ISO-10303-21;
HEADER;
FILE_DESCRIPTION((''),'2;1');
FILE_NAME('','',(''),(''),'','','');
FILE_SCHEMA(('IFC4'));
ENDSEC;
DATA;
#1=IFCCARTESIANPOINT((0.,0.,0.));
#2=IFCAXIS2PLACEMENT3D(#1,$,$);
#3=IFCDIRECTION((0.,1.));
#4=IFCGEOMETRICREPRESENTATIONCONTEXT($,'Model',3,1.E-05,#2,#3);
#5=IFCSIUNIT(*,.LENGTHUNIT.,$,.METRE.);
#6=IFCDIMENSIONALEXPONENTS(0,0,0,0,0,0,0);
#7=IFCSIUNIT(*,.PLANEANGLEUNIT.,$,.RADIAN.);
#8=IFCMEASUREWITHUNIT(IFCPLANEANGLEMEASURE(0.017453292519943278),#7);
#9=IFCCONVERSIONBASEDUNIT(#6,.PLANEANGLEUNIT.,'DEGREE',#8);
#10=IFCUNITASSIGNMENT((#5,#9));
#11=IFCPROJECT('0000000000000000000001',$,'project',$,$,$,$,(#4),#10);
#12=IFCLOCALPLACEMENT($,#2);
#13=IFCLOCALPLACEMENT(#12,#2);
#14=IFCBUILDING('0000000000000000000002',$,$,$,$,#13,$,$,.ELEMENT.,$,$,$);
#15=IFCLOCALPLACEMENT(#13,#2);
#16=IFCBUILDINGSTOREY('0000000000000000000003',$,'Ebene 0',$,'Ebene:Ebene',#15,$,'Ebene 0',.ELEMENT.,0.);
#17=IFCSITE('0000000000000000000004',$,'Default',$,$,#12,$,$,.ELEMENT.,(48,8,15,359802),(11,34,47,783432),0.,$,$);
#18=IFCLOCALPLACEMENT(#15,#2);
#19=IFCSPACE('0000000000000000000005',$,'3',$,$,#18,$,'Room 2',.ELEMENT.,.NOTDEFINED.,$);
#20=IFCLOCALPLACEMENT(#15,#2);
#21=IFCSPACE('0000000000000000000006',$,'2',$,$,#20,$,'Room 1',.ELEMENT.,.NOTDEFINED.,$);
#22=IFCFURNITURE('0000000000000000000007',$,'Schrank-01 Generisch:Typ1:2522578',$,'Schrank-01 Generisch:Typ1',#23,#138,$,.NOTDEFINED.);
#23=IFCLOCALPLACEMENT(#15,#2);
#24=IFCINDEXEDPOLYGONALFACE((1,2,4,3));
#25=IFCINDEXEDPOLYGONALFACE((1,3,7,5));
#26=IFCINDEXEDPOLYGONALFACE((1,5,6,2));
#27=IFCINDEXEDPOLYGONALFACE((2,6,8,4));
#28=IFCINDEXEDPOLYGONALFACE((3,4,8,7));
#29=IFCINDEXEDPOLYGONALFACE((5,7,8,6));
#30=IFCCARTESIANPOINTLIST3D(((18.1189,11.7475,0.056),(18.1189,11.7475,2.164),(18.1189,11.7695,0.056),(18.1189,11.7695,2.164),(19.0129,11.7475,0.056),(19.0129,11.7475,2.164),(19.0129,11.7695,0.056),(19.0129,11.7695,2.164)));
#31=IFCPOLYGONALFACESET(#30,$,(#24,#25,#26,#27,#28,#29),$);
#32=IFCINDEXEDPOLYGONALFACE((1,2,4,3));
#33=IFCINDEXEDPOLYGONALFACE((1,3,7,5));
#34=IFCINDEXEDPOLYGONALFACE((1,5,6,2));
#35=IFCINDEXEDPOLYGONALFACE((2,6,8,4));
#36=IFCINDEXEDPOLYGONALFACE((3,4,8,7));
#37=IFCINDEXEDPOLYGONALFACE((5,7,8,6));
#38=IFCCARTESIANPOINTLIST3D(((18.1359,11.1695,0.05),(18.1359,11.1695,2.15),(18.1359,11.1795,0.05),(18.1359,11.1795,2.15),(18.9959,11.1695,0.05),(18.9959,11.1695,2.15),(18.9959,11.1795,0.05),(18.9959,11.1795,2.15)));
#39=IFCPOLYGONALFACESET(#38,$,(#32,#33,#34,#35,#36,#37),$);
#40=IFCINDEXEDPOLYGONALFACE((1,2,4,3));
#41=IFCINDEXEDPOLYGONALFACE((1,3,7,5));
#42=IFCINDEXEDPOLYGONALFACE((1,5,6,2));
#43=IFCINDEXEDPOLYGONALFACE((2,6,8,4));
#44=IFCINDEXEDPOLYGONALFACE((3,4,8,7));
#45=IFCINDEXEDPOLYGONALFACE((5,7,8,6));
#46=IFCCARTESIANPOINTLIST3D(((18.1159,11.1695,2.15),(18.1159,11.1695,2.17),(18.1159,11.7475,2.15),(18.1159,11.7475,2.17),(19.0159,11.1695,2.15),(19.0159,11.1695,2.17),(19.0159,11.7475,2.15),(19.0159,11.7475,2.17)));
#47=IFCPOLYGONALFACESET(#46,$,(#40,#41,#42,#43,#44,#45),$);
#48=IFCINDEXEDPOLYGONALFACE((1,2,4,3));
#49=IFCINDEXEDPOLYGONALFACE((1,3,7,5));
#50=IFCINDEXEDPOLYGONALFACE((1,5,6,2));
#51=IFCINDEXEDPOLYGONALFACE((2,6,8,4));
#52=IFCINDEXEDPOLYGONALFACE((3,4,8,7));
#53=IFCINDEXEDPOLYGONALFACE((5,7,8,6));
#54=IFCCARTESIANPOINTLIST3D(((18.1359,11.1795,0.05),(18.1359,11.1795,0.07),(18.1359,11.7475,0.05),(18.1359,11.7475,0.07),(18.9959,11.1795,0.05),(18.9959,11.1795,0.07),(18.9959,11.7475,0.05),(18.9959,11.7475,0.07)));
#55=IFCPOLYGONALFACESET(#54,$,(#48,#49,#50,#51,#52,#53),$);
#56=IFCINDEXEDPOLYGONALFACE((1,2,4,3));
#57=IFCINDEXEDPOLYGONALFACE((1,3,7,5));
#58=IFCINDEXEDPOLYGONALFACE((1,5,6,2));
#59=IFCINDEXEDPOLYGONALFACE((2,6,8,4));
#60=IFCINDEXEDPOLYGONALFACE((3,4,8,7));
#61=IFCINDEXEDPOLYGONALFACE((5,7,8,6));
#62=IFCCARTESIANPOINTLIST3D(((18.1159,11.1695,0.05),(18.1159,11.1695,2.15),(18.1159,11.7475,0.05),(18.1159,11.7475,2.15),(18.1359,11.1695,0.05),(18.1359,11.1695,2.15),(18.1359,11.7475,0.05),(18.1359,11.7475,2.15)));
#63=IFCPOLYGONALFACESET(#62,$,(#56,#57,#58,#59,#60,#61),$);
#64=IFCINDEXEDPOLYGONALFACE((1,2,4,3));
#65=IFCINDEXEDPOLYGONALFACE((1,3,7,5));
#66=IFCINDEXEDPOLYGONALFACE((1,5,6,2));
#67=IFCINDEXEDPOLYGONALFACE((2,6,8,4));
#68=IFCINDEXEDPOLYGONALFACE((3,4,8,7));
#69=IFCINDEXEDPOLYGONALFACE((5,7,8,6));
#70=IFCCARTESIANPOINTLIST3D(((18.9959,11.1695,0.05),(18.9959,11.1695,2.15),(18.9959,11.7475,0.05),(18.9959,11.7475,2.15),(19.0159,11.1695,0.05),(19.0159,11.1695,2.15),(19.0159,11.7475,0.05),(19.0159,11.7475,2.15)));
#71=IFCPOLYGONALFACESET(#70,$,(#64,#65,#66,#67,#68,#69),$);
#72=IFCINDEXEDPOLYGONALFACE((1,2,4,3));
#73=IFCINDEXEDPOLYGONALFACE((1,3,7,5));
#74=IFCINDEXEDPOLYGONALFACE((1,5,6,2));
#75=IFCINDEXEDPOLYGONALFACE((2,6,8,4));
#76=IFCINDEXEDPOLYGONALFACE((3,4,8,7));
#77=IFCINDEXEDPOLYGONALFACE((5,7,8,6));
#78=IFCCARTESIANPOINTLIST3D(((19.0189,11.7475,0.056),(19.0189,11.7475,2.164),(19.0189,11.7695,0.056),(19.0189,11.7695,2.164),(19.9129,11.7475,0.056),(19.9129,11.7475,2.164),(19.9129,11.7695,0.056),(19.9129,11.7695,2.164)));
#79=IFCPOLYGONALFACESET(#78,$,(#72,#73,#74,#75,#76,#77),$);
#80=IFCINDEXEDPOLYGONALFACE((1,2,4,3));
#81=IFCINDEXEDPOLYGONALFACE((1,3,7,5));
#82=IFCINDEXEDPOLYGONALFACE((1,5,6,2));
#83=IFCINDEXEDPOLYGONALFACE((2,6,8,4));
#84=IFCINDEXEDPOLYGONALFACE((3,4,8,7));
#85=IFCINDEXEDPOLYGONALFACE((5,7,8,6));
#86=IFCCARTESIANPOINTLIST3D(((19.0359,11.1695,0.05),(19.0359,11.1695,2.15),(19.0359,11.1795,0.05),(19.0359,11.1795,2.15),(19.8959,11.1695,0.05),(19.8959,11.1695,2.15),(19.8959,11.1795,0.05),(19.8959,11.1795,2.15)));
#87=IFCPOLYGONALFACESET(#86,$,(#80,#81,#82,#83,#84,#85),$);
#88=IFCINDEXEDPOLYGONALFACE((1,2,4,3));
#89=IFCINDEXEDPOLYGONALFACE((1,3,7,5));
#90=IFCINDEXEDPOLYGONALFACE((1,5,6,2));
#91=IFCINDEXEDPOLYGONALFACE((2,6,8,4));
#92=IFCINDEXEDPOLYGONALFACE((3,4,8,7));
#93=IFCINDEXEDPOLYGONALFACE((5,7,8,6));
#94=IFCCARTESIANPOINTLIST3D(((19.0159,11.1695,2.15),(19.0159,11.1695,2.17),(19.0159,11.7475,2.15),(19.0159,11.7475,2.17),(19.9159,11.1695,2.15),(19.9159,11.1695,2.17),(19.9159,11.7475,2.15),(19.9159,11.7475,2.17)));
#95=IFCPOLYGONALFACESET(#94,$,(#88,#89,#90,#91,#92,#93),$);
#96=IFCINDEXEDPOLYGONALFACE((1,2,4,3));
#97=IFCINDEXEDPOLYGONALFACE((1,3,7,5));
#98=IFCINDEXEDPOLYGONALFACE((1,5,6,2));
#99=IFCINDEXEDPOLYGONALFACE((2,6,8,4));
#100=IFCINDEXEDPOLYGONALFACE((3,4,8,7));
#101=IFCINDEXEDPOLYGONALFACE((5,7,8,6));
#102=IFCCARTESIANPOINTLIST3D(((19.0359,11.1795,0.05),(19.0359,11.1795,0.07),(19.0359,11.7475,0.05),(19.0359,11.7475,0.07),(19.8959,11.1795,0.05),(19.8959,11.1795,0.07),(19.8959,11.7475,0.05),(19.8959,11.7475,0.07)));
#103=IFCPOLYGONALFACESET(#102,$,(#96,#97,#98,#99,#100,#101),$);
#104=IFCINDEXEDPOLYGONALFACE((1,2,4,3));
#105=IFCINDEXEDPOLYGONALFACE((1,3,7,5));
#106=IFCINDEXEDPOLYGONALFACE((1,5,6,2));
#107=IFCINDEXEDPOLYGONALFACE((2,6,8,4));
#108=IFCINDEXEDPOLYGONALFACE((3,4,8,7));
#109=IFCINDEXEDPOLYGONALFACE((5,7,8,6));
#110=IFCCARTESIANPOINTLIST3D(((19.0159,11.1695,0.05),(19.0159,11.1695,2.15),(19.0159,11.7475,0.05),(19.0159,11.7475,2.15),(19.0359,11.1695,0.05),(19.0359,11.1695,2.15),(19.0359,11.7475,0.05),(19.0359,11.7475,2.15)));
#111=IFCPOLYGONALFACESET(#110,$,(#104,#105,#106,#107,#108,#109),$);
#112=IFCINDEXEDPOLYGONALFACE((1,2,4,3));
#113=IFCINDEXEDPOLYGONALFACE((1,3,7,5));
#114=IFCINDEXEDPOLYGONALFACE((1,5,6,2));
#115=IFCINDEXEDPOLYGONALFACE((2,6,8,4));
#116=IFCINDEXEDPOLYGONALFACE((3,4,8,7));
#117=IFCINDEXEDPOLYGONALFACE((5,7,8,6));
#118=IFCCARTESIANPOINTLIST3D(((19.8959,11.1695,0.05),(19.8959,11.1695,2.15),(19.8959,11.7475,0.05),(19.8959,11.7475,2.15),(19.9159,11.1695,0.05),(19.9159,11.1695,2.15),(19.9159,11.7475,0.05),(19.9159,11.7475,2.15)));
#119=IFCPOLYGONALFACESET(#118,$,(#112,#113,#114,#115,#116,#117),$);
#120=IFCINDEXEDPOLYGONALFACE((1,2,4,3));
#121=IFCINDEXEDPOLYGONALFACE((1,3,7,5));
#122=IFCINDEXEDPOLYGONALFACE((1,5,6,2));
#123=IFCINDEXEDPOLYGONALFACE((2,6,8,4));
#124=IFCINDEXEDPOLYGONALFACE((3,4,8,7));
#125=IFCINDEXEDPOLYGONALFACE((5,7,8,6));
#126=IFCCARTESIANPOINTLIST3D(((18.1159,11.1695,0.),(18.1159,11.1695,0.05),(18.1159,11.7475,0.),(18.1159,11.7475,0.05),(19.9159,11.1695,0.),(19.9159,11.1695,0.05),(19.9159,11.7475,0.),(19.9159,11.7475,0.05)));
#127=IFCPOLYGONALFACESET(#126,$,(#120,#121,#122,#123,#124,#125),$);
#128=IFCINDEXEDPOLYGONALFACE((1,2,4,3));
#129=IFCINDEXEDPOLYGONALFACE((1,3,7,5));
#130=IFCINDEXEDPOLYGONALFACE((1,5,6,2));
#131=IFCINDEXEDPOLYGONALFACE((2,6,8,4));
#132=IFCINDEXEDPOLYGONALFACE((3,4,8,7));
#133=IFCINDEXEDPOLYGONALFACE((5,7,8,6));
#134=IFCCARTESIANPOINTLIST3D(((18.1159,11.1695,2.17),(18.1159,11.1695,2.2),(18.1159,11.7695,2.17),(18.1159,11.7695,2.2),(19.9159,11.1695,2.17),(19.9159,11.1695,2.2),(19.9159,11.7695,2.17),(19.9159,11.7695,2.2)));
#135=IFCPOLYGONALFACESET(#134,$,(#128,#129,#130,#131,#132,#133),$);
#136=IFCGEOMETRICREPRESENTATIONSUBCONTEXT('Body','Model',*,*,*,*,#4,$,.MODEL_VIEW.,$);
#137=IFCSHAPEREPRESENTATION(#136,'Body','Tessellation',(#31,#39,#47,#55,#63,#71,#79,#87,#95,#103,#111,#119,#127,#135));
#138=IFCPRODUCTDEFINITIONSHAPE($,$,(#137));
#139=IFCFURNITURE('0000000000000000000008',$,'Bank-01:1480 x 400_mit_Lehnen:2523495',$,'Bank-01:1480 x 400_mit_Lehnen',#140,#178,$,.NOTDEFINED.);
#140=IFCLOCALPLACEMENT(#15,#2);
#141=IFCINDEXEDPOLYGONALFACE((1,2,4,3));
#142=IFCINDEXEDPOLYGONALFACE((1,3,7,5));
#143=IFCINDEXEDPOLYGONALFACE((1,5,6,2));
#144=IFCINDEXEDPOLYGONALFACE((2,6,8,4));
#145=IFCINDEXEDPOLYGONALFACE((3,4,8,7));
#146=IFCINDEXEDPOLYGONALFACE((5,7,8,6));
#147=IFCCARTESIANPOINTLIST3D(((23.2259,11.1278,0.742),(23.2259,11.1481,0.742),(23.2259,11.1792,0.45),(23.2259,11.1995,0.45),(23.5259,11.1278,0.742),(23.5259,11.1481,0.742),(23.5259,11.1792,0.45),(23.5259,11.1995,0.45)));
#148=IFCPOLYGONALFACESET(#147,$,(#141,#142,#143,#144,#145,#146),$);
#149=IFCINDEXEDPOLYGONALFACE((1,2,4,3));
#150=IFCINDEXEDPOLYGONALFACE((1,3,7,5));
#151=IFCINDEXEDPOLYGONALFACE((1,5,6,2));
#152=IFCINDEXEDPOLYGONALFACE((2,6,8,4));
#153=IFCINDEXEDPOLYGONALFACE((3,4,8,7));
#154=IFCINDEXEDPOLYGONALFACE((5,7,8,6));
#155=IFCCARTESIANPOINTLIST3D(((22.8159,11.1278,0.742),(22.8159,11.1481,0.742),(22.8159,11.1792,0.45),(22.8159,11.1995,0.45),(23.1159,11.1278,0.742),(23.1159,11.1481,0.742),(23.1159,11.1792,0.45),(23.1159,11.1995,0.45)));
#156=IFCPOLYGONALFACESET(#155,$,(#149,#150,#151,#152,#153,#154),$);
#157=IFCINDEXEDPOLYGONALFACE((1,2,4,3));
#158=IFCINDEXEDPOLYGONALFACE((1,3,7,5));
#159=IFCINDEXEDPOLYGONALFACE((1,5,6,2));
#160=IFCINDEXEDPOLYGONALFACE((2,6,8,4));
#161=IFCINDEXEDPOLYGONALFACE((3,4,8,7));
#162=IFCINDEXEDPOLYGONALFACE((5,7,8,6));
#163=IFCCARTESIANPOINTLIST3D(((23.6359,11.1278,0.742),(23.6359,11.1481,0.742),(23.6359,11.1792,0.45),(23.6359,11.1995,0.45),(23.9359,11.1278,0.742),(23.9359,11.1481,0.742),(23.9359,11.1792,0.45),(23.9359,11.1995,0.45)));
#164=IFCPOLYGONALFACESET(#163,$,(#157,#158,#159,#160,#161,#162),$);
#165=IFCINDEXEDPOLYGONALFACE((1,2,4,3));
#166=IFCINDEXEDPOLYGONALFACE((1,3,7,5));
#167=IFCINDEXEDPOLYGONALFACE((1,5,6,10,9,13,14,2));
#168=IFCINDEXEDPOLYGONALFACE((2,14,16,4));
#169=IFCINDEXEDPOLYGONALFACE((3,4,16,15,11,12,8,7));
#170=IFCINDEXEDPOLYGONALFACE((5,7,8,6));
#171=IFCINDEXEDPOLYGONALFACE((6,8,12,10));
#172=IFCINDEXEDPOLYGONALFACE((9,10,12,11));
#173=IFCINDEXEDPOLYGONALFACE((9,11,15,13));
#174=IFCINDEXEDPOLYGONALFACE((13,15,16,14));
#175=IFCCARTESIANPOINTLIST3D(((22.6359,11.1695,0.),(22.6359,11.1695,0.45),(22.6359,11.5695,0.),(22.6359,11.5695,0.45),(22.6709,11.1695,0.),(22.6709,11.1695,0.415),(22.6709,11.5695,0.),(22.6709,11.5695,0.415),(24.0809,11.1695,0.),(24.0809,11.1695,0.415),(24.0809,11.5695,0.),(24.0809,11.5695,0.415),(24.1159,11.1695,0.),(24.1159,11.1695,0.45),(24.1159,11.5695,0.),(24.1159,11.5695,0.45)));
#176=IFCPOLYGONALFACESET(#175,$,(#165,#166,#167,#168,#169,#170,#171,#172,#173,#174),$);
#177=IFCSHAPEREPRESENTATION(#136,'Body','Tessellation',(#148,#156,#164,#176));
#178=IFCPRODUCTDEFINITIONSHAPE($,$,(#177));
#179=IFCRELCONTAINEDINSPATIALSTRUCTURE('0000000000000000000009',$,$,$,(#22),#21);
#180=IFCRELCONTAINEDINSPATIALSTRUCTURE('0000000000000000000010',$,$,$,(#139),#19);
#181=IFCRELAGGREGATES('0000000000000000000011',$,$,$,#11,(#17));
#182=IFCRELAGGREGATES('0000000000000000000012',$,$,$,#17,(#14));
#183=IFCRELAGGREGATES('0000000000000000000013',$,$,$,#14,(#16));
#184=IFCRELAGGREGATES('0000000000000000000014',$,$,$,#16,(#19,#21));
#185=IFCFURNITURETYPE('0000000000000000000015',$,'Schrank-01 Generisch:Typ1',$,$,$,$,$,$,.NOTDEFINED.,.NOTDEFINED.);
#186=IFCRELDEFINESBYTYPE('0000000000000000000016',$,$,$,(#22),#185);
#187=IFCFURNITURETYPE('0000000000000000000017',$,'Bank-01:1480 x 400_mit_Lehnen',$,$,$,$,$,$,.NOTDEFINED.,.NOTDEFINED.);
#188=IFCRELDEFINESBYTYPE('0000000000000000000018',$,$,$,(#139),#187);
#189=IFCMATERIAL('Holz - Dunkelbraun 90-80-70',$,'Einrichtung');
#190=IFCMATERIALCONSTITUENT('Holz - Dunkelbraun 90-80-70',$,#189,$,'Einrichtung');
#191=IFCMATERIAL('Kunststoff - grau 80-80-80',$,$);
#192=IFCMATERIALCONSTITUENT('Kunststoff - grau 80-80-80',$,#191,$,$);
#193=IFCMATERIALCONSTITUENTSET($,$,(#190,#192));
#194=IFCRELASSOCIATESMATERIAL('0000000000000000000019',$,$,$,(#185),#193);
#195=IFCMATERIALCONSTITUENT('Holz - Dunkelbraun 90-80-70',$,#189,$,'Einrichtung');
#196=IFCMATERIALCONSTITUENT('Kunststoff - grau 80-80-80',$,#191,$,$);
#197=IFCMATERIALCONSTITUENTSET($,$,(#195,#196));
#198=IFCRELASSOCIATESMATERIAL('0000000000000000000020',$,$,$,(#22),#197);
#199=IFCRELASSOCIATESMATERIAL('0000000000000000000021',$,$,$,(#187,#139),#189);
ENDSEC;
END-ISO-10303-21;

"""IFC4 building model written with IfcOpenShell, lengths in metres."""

from ifc_helpers import new_model, entity, si_unit, converted_unit, direction, frame, origin, place, context, subcontext, project, spatial, indexed_curve, outline, extrude, source, transform, mapped, material, constituent, constituent_set, type_object, type_shapes, element, save


model = new_model("IFC4")

# Units and contexts
model_context = context("Model", 3, precision=1e-05, world=origin(), true_north=direction((0.0, 1.0)))
body_context = subcontext(model_context, "Body", "Model", "MODEL_VIEW")
ifc_project = project(units=[si_unit("LENGTHUNIT", "METRE"), converted_unit("PLANEANGLEUNIT", "DEGREE", entity("IfcPlaneAngleMeasure", 0.017453292519943278), si_unit("PLANEANGLEUNIT", "RADIAN"), dimensions=[0, 0, 0, 0, 0, 0, 0])], contexts=[model_context])

# Site, building, storey
site_placement = place(None, origin())
site = spatial("IfcSite", under=ifc_project, at=site_placement, Name="Default", CompositionType="ELEMENT", RefLatitude=(48, 8, 15, 359802), RefLongitude=(11, 34, 47, 783432), RefElevation=0.0)
building_placement = place(site_placement, origin())
building = spatial("IfcBuilding", under=site, at=building_placement, CompositionType="ELEMENT")
storey_placement = place(building_placement, origin())
storey = spatial("IfcBuildingStorey", under=building, at=storey_placement, Name="Ebene 0", ObjectType="Ebene:Ebene", LongName="Ebene 0", CompositionType="ELEMENT", Elevation=0.0)

# Shared definitions
ifc_material_1 = material(Name="Holz - Dunkelbraun 90-80-70", Category="Einrichtung")
ifc_material_2 = material(Name="Kunststoff - grau 80-80-80")

# Shared definitions
ifc_constituent_1 = constituent(ifc_material_1, Name="Holz - Dunkelbraun 90-80-70", Category="Einrichtung")
ifc_constituent_2 = constituent(ifc_material_2, Name="Kunststoff - grau 80-80-80")
ifc_constituent_set_1 = constituent_set(constituents=[ifc_constituent_1, ifc_constituent_2])
furniture_type_1 = type_object("IfcFurnitureType", Name="Schrank-01 Generisch:Typ1", AssemblyPlace="NOTDEFINED", PredefinedType="NOTDEFINED", material=ifc_constituent_set_1)
shared_shape_1 = source(origin(), body_context, "Body", "SweptSolid", [
    extrude(outline(indexed_curve([(-0.447, -0.011), (0.447, -0.011), (0.447, 0.011), (-0.447, 0.011), (-0.447, -0.011)], self_intersect=False)), frame((0.45, -0.289, 0.056), z_axis=(0.0, 0.0, 1.0), x_axis=(-1.0, 0.0, 0.0)), (0.0, 0.0, 1.0), 2.108),
    extrude(outline(indexed_curve([(-0.43, -0.005), (0.43, -0.005), (0.43, 0.005), (-0.43, 0.005), (-0.43, -0.005)], self_intersect=False)), frame((0.45, 0.295, 0.05), z_axis=(0.0, 0.0, 1.0), x_axis=(-1.0, 0.0, 0.0)), (0.0, 0.0, 1.0), 2.1),
    extrude(outline(indexed_curve([(-0.45, -0.289), (0.45, -0.289), (0.45, 0.289), (-0.45, 0.289), (-0.45, -0.289)], self_intersect=False)), frame((0.45, 0.011, 2.15), z_axis=(0.0, 0.0, 1.0), x_axis=(-1.0, 0.0, 0.0)), (0.0, 0.0, 1.0), 0.02),
    extrude(outline(indexed_curve([(-0.43, -0.284), (0.43, -0.284), (0.43, 0.284), (-0.43, 0.284), (-0.43, -0.284)], self_intersect=False)), frame((0.45, 0.006, 0.05), z_axis=(0.0, 0.0, 1.0), x_axis=(-1.0, 0.0, 0.0)), (0.0, 0.0, 1.0), 0.02),
    extrude(outline(indexed_curve([(-0.01, -0.289), (0.01, -0.289), (0.01, 0.289), (-0.01, 0.289), (-0.01, -0.289)], self_intersect=False)), frame((0.89, 0.011, 0.05), z_axis=(0.0, 0.0, 1.0), x_axis=(-1.0, 0.0, 0.0)), (0.0, 0.0, 1.0), 2.1),
    extrude(outline(indexed_curve([(-0.01, -0.289), (0.01, -0.289), (0.01, 0.289), (-0.01, 0.289), (-0.01, -0.289)], self_intersect=False)), frame((0.01, 0.011, 0.05), z_axis=(0.0, 0.0, 1.0), x_axis=(-1.0, 0.0, 0.0)), (0.0, 0.0, 1.0), 2.1),
    extrude(outline(indexed_curve([(-0.447, -0.011), (0.447, -0.011), (0.447, 0.011), (-0.447, 0.011), (-0.447, -0.011)], self_intersect=False)), frame((-0.45, -0.289, 0.056), z_axis=(0.0, 0.0, 1.0), x_axis=(-1.0, 0.0, 0.0)), (0.0, 0.0, 1.0), 2.108),
    extrude(outline(indexed_curve([(-0.43, -0.005), (0.43, -0.005), (0.43, 0.005), (-0.43, 0.005), (-0.43, -0.005)], self_intersect=False)), frame((-0.45, 0.295, 0.05), z_axis=(0.0, 0.0, 1.0), x_axis=(-1.0, 0.0, 0.0)), (0.0, 0.0, 1.0), 2.1),
    extrude(outline(indexed_curve([(-0.45, -0.289), (0.45, -0.289), (0.45, 0.289), (-0.45, 0.289), (-0.45, -0.289)], self_intersect=False)), frame((-0.45, 0.011, 2.15), z_axis=(0.0, 0.0, 1.0), x_axis=(-1.0, 0.0, 0.0)), (0.0, 0.0, 1.0), 0.02),
    extrude(outline(indexed_curve([(-0.43, -0.284), (0.43, -0.284), (0.43, 0.284), (-0.43, 0.284), (-0.43, -0.284)], self_intersect=False)), frame((-0.45, 0.006, 0.05), z_axis=(0.0, 0.0, 1.0), x_axis=(-1.0, 0.0, 0.0)), (0.0, 0.0, 1.0), 0.02),
    extrude(outline(indexed_curve([(-0.01, -0.289), (0.01, -0.289), (0.01, 0.289), (-0.01, 0.289), (-0.01, -0.289)], self_intersect=False)), frame((-0.01, 0.011, 0.05), z_axis=(0.0, 0.0, 1.0), x_axis=(-1.0, 0.0, 0.0)), (0.0, 0.0, 1.0), 2.1),
    extrude(outline(indexed_curve([(-0.01, -0.289), (0.01, -0.289), (0.01, 0.289), (-0.01, 0.289), (-0.01, -0.289)], self_intersect=False)), frame((-0.89, 0.011, 0.05), z_axis=(0.0, 0.0, 1.0), x_axis=(-1.0, 0.0, 0.0)), (0.0, 0.0, 1.0), 2.1),
    extrude(outline(indexed_curve([(-0.9, -0.289), (0.9, -0.289), (0.9, 0.289), (-0.9, 0.289), (-0.9, -0.289)], self_intersect=False)), frame((0.0, 0.011, 0.0), z_axis=(0.0, 0.0, 1.0), x_axis=(-1.0, 0.0, 0.0)), (0.0, 0.0, 1.0), 0.05),
    extrude(outline(indexed_curve([(-0.9, -0.3), (0.9, -0.3), (0.9, 0.3), (-0.9, 0.3), (-0.9, -0.3)], self_intersect=False)), frame((0.0, 0.0, 2.17), z_axis=(0.0, 0.0, 1.0), x_axis=(-1.0, 0.0, 0.0)), (0.0, 0.0, 1.0), 0.03),
])
type_shapes(furniture_type_1, [shared_shape_1])

# Shared definitions
space_1_placement = place(storey_placement, origin())
space_1 = spatial("IfcSpace", under=storey, at=space_1_placement, Name="3", LongName="Room 2", CompositionType="ELEMENT", PredefinedType="NOTDEFINED")

# Shared definitions
space_2_placement = place(storey_placement, origin())
space_2 = spatial("IfcSpace", under=storey, at=space_2_placement, Name="2", LongName="Room 1", CompositionType="ELEMENT", PredefinedType="NOTDEFINED")

# Furniture
ifc_constituent_3 = constituent(ifc_material_1, Name="Holz - Dunkelbraun 90-80-70", Category="Einrichtung")
ifc_constituent_4 = constituent(ifc_material_2, Name="Kunststoff - grau 80-80-80")
ifc_constituent_set_2 = constituent_set(constituents=[ifc_constituent_3, ifc_constituent_4])
furniture_1_placement = place(space_2_placement, frame((19.0159, 11.4695, 0.0), z_axis=(0.0, 0.0, 1.0), x_axis=(-1.0, 0.0, 0.0)))
element("IfcFurniture", 1, at=furniture_1_placement, inside=space_2, type_object=furniture_type_1, material=ifc_constituent_set_2, Name="Schrank-01 Generisch:Typ1:2522578", ObjectType="Schrank-01 Generisch:Typ1", PredefinedType="NOTDEFINED", context=body_context, shape_type="MappedRepresentation", body=[
    mapped(shared_shape_1, transform((0.0, 0.0, 0.0), scale=1.0)),
])

# Furniture
furniture_type_2 = type_object("IfcFurnitureType", Name="Bank-01:1480 x 400_mit_Lehnen", AssemblyPlace="NOTDEFINED", PredefinedType="NOTDEFINED", material=ifc_material_1)
shared_shape_2 = source(origin(), body_context, "Body", "SweptSolid", [
    extrude(outline(indexed_curve([(0.0156, -0.146), (0.0359, -0.146), (-0.0156, 0.146), (-0.0359, 0.146), (0.0156, -0.146)], self_intersect=False)), frame((-0.3053, -0.3866, 0.596), z_axis=(1.0, 0.0, 0.0), x_axis=(0.0, -1.0, 0.0)), (0.0, 0.0, 1.0), 0.3),
    extrude(outline(indexed_curve([(0.0156, -0.146), (0.0359, -0.146), (-0.0156, 0.146), (-0.0359, 0.146), (0.0156, -0.146)], self_intersect=False)), frame((-0.7153, -0.3866, 0.596), z_axis=(1.0, 0.0, 0.0), x_axis=(0.0, -1.0, 0.0)), (0.0, 0.0, 1.0), 0.3),
    extrude(outline(indexed_curve([(0.0156, -0.146), (0.0359, -0.146), (-0.0156, 0.146), (-0.0359, 0.146), (0.0156, -0.146)], self_intersect=False)), frame((0.1047, -0.3866, 0.596), z_axis=(1.0, 0.0, 0.0), x_axis=(0.0, -1.0, 0.0)), (0.0, 0.0, 1.0), 0.3),
    extrude(outline(indexed_curve([(-0.74, -0.2337), (0.74, -0.2337), (0.74, 0.2163), (0.705, 0.2163), (0.705, -0.1988), (-0.705, -0.1988), (-0.705, 0.2163), (-0.74, 0.2163), (-0.74, -0.2337)], self_intersect=False)), frame((-0.1553, -0.3807, 0.2163), z_axis=(0.0, 1.0, 0.0), x_axis=(1.0, 0.0, 0.0)), (0.0, 0.0, 1.0), 0.4),
])
type_shapes(furniture_type_2, [shared_shape_2])
furniture_2_placement = place(space_1_placement, frame((23.5313, 11.5503, 0.0)))
element("IfcFurniture", 2, at=furniture_2_placement, inside=space_1, type_object=furniture_type_2, material=ifc_material_1, Name="Bank-01:1480 x 400_mit_Lehnen:2523495", ObjectType="Bank-01:1480 x 400_mit_Lehnen", PredefinedType="NOTDEFINED", context=body_context, shape_type="MappedRepresentation", body=[
    mapped(shared_shape_2, transform((0.0, 0.0, 0.0), scale=1.0)),
])

save(model, "model.ifc")
